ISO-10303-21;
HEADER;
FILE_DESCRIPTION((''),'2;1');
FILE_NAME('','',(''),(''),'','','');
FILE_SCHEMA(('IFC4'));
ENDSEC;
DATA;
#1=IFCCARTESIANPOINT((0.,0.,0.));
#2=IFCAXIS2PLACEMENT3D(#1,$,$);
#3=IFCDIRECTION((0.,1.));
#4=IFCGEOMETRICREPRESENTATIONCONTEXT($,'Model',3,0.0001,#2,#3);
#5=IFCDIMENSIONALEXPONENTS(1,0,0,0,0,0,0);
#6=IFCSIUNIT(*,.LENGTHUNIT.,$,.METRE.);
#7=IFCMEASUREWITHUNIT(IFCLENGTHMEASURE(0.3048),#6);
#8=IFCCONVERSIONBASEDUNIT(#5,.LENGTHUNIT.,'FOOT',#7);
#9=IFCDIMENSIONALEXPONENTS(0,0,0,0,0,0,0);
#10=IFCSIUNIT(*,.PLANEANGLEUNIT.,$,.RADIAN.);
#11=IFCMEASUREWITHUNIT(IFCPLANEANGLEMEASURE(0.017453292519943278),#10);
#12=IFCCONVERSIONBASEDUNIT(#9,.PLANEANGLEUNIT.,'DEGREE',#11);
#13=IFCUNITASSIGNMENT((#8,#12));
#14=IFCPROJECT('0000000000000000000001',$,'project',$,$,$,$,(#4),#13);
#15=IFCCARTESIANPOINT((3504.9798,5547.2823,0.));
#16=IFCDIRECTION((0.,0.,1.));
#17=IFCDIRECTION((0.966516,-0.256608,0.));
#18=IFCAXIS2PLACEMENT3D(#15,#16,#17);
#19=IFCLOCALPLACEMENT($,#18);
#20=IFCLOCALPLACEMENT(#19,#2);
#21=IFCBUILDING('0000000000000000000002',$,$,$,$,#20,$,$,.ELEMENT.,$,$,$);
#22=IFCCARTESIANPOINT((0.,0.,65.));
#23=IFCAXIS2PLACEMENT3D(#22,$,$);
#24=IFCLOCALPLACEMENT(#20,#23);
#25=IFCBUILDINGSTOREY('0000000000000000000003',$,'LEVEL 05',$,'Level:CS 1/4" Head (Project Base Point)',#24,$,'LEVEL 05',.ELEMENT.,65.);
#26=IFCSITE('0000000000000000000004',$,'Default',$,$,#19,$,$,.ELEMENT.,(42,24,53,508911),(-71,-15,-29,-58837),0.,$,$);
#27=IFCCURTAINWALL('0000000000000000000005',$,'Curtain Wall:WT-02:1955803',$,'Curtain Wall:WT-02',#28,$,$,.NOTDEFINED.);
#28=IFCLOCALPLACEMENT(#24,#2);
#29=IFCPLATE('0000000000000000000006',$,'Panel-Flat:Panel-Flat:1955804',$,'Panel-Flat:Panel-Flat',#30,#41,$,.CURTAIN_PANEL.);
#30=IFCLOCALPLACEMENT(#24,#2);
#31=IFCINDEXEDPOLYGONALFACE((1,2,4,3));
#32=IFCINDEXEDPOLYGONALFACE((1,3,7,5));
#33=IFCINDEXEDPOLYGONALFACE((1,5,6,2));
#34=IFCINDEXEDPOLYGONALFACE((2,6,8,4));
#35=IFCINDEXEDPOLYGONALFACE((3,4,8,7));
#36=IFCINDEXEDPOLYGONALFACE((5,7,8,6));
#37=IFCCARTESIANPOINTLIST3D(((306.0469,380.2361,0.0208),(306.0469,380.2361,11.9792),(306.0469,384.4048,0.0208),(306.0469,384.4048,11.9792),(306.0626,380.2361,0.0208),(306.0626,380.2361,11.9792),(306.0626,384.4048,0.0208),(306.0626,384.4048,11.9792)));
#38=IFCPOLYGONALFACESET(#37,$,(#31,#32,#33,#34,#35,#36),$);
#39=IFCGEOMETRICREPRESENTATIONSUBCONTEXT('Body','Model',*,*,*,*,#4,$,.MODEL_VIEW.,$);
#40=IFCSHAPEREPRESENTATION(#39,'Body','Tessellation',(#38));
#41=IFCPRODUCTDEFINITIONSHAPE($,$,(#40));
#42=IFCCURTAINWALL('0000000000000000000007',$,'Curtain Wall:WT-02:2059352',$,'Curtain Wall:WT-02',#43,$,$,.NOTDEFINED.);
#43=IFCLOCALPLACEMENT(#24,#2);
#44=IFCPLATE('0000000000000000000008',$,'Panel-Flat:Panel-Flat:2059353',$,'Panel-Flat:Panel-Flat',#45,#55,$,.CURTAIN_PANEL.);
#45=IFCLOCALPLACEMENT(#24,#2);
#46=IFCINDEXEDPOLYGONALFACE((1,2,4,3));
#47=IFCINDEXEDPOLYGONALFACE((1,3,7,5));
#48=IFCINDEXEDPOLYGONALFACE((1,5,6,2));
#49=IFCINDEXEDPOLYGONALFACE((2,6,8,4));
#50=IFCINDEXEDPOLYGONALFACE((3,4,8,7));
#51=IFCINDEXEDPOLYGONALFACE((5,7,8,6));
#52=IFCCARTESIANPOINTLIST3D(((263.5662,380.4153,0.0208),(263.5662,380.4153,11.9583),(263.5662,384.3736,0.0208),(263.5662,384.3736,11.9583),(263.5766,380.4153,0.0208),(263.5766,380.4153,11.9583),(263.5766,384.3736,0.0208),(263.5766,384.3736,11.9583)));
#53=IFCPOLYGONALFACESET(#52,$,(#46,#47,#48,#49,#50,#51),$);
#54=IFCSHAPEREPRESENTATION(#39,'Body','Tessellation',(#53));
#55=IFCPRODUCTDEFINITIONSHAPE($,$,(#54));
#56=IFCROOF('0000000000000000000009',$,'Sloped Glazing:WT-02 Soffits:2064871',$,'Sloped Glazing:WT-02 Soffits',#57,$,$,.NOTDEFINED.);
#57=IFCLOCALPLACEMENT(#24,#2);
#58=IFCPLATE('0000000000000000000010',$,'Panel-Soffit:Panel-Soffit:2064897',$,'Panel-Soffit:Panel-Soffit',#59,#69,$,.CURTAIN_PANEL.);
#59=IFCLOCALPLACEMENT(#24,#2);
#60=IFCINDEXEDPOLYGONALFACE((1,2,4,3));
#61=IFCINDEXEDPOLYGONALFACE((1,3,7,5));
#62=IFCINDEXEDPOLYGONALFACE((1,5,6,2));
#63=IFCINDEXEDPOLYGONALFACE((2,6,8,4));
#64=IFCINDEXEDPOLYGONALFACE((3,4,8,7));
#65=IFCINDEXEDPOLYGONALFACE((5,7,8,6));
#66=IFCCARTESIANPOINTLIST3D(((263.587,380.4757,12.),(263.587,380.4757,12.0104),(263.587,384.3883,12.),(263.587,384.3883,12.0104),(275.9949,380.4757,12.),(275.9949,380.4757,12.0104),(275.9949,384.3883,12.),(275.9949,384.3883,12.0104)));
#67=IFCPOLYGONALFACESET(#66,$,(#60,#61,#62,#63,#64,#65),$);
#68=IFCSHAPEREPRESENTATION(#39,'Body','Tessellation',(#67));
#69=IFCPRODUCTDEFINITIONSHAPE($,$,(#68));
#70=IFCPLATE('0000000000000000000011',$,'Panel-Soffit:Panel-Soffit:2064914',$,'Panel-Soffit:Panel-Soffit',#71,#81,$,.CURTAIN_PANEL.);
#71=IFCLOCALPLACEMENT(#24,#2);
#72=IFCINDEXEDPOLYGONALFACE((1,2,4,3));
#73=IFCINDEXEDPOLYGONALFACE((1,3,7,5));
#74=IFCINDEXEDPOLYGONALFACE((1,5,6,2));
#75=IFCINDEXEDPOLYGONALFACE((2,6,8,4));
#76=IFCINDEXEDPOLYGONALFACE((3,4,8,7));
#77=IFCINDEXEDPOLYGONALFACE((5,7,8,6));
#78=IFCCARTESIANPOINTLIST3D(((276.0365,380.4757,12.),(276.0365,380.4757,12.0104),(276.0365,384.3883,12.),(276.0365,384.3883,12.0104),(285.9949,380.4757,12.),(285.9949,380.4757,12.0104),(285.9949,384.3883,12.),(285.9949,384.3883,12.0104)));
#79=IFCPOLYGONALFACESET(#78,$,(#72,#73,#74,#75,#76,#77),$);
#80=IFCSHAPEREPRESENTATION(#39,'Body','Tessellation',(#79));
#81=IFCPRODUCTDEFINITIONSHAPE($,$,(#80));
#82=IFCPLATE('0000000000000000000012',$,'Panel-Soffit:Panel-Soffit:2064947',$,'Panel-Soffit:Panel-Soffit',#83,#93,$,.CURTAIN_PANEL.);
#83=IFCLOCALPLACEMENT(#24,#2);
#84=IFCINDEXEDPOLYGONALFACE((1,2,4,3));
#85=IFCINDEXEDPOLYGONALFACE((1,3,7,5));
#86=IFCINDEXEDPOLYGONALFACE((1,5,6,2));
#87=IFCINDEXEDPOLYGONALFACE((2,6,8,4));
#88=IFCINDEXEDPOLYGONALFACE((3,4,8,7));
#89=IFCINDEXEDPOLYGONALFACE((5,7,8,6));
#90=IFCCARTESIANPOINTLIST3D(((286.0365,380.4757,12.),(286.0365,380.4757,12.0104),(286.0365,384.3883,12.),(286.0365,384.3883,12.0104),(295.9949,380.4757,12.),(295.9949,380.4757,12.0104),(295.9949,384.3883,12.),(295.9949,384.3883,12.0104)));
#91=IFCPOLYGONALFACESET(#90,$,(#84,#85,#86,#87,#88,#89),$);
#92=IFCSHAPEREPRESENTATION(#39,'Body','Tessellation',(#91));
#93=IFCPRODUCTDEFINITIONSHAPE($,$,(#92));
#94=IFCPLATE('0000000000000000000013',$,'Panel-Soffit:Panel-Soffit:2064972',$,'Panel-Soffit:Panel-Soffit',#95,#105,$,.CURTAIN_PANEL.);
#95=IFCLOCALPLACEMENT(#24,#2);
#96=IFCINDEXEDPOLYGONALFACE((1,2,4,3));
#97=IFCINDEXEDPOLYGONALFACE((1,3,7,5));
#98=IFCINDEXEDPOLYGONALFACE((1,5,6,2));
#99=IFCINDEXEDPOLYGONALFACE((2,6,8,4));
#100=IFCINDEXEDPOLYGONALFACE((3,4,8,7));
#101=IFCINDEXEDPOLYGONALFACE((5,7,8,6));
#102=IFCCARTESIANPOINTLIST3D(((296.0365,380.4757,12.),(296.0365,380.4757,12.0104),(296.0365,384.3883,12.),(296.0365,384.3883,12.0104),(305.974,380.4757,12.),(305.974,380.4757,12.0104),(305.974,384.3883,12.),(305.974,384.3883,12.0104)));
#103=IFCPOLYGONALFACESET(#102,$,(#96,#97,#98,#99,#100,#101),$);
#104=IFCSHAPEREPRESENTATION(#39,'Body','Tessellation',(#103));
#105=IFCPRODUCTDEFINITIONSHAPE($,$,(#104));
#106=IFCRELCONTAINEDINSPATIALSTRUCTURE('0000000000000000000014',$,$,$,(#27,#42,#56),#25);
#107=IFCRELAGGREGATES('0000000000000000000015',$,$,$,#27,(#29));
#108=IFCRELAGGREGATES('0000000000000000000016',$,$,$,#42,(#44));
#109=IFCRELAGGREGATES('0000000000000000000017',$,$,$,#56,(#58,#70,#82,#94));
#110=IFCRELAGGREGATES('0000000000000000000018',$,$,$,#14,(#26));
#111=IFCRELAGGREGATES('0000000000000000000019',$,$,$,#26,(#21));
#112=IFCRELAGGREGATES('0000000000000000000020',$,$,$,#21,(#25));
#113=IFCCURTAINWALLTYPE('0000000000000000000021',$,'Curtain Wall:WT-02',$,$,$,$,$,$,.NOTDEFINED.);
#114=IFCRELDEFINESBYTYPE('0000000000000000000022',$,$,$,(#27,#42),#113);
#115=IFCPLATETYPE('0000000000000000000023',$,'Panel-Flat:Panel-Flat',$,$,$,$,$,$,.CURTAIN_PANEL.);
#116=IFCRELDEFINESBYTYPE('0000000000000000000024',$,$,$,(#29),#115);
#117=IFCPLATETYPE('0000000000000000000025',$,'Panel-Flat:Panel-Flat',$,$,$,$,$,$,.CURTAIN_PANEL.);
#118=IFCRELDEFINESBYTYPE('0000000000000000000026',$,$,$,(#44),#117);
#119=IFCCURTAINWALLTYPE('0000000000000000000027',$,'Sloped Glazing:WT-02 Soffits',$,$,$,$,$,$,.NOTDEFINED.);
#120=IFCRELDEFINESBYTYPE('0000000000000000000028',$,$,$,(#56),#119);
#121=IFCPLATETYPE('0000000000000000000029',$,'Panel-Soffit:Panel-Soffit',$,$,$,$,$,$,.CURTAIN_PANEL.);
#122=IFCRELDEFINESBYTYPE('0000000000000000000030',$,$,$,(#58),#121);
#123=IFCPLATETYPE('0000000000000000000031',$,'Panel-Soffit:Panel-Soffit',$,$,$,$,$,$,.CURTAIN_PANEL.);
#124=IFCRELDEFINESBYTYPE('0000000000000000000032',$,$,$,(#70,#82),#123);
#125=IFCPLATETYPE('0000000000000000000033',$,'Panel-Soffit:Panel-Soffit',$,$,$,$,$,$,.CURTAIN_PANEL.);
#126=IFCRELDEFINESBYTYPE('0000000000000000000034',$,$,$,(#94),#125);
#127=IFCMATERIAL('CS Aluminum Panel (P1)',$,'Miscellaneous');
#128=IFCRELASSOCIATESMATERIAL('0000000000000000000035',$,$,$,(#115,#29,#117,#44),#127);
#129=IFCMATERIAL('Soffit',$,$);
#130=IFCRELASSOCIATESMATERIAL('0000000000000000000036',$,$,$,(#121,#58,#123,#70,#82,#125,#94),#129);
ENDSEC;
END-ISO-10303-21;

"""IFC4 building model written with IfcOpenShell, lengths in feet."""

from ifc_helpers import new_model, entity, si_unit, converted_unit, direction, frame, origin, place, context, subcontext, project, spatial, indexed_curve, outline, extrude, source, transform, mapped, material, type_object, type_shapes, element, aggregate, save


model = new_model("IFC4")

# Units and contexts
model_context = context("Model", 3, precision=0.0001, world=origin(), true_north=direction((0.0, 1.0)))
body_context = subcontext(model_context, "Body", "Model", "MODEL_VIEW")
ifc_project = project(units=[converted_unit("LENGTHUNIT", "FOOT", entity("IfcLengthMeasure", 0.3048), si_unit("LENGTHUNIT", "METRE"), dimensions=[1, 0, 0, 0, 0, 0, 0]), converted_unit("PLANEANGLEUNIT", "DEGREE", entity("IfcPlaneAngleMeasure", 0.017453292519943278), si_unit("PLANEANGLEUNIT", "RADIAN"), dimensions=[0, 0, 0, 0, 0, 0, 0])], contexts=[model_context])

# Site, building, storey
site_placement = place(None, frame((3504.9798, 5547.2823, 0.0), z_axis=(0.0, 0.0, 1.0), x_axis=(0.966516, -0.256608, 0.0)))
site = spatial("IfcSite", under=ifc_project, at=site_placement, Name="Default", CompositionType="ELEMENT", RefLatitude=(42, 24, 53, 508911), RefLongitude=(-71, -15, -29, -58837), RefElevation=0.0)
building_placement = place(site_placement, origin())
building = spatial("IfcBuilding", under=site, at=building_placement, CompositionType="ELEMENT")
storey_placement = place(building_placement, frame((0.0, 0.0, 65.0)))
storey = spatial("IfcBuildingStorey", under=building, at=storey_placement, Name="LEVEL 05", ObjectType="Level:CS 1/4\" Head (Project Base Point)", LongName="LEVEL 05", CompositionType="ELEMENT", Elevation=65.0)

# Curtain wall, plate
curtain_wall_type_1 = type_object("IfcCurtainWallType", Name="Curtain Wall:WT-02", PredefinedType="NOTDEFINED")
curtain_wall_1_placement = place(storey_placement, frame((0.0, 0.0, -65.0)))
curtain_wall_1 = element("IfcCurtainWall", 1, at=curtain_wall_1_placement, inside=storey, type_object=curtain_wall_type_1, Name="Curtain Wall:WT-02:1955803", ObjectType="Curtain Wall:WT-02", PredefinedType="NOTDEFINED")
ifc_material_1 = material(Name="CS Aluminum Panel (P1)", Category="Miscellaneous")
plate_type_1 = type_object("IfcPlateType", Name="Panel-Flat:Panel-Flat", PredefinedType="CURTAIN_PANEL", material=ifc_material_1)
shared_shape_1 = source(origin(), body_context, "Body", "SweptSolid", [
    extrude(outline(indexed_curve([(-0.0078, -2.0843), (0.0078, -2.0843), (0.0078, 2.0843), (-0.0078, 2.0843), (-0.0078, -2.0843)], self_intersect=False)), frame((0.0, -0.0078, 0.0208), z_axis=(0.0, 0.0, 1.0), x_axis=(0.0, -1.0, 0.0)), (0.0, 0.0, 1.0), 11.9583),
])
type_shapes(plate_type_1, [shared_shape_1])
plate_1_placement = place(curtain_wall_1_placement, frame((306.0469, 382.3205, 65.0), z_axis=(0.0, 0.0, 1.0), x_axis=(0.0, 1.0, 0.0)))
plate_1 = element("IfcPlate", 2, at=plate_1_placement, type_object=plate_type_1, material=ifc_material_1, Name="Panel-Flat:Panel-Flat:1955804", ObjectType="Panel-Flat:Panel-Flat", PredefinedType="CURTAIN_PANEL", context=body_context, shape_type="MappedRepresentation", body=[
    mapped(shared_shape_1, transform((0.0, 0.0, 0.0), scale=1.0)),
])
aggregate(curtain_wall_1, [plate_1])

# Curtain wall, plate
curtain_wall_2_placement = place(storey_placement, frame((0.0, 0.0, -65.0)))
curtain_wall_2 = element("IfcCurtainWall", 3, at=curtain_wall_2_placement, inside=storey, type_object=curtain_wall_type_1, Name="Curtain Wall:WT-02:2059352", ObjectType="Curtain Wall:WT-02", PredefinedType="NOTDEFINED")
plate_type_2 = type_object("IfcPlateType", Name="Panel-Flat:Panel-Flat", PredefinedType="CURTAIN_PANEL", material=ifc_material_1)
shared_shape_2 = source(origin(), body_context, "Body", "SweptSolid", [
    extrude(outline(indexed_curve([(-0.0052, -1.9792), (0.0052, -1.9792), (0.0052, 1.9792), (-0.0052, 1.9792), (-0.0052, -1.9792)], self_intersect=False)), frame((0.0, -0.0052, 0.0208), z_axis=(0.0, 0.0, 1.0), x_axis=(0.0, -1.0, 0.0)), (0.0, 0.0, 1.0), 11.9375),
])
type_shapes(plate_type_2, [shared_shape_2])
plate_2_placement = place(curtain_wall_2_placement, frame((263.5766, 382.3944, 65.0), z_axis=(0.0, 0.0, 1.0), x_axis=(0.0, -1.0, 0.0)))
plate_2 = element("IfcPlate", 4, at=plate_2_placement, type_object=plate_type_2, material=ifc_material_1, Name="Panel-Flat:Panel-Flat:2059353", ObjectType="Panel-Flat:Panel-Flat", PredefinedType="CURTAIN_PANEL", context=body_context, shape_type="MappedRepresentation", body=[
    mapped(shared_shape_2, transform((0.0, 0.0, 0.0), scale=1.0)),
])
aggregate(curtain_wall_2, [plate_2])

# Roof, plates
curtain_wall_type_2 = type_object("IfcCurtainWallType", Name="Sloped Glazing:WT-02 Soffits", PredefinedType="NOTDEFINED")
roof_placement = place(storey_placement, frame((0.0, 0.0, -65.0)))
roof = element("IfcRoof", 5, at=roof_placement, inside=storey, type_object=curtain_wall_type_2, Name="Sloped Glazing:WT-02 Soffits:2064871", ObjectType="Sloped Glazing:WT-02 Soffits", PredefinedType="NOTDEFINED")
ifc_material_2 = material(Name="Soffit")
plate_type_3 = type_object("IfcPlateType", Name="Panel-Soffit:Panel-Soffit", PredefinedType="CURTAIN_PANEL", material=ifc_material_2)
shared_shape_3 = source(origin(), body_context, "Body", "SweptSolid", [
    extrude(outline(indexed_curve([(-0.0052, -6.2039), (0.0052, -6.2039), (0.0052, 6.2039), (-0.0052, 6.2039), (-0.0052, -6.2039)], self_intersect=False)), frame((0.0, -0.0052, 0.0208), z_axis=(0.0, 0.0, 1.0), x_axis=(0.0, -1.0, 0.0)), (0.0, 0.0, 1.0), 3.9126),
])
type_shapes(plate_type_3, [shared_shape_3])
plate_3_placement = place(roof_placement, frame((269.7909, 380.4549, 77.0), z_axis=(0.0, 1.0, 0.0), x_axis=(1.0, 0.0, 0.0)))
plate_3 = element("IfcPlate", 6, at=plate_3_placement, type_object=plate_type_3, material=ifc_material_2, Name="Panel-Soffit:Panel-Soffit:2064897", ObjectType="Panel-Soffit:Panel-Soffit", PredefinedType="CURTAIN_PANEL", context=body_context, shape_type="MappedRepresentation", body=[
    mapped(shared_shape_3, transform((0.0, 0.0, 0.0), scale=1.0)),
])
plate_type_4 = type_object("IfcPlateType", Name="Panel-Soffit:Panel-Soffit", PredefinedType="CURTAIN_PANEL", material=ifc_material_2)
shared_shape_4 = source(origin(), body_context, "Body", "SweptSolid", [
    extrude(outline(indexed_curve([(-0.0052, -4.9792), (0.0052, -4.9792), (0.0052, 4.9792), (-0.0052, 4.9792), (-0.0052, -4.9792)], self_intersect=False)), frame((0.0, -0.0052, 0.0208), z_axis=(0.0, 0.0, 1.0), x_axis=(0.0, -1.0, 0.0)), (0.0, 0.0, 1.0), 3.9126),
])
type_shapes(plate_type_4, [shared_shape_4])
plate_4_placement = place(roof_placement, frame((281.0157, 380.4549, 77.0), z_axis=(0.0, 1.0, 0.0), x_axis=(1.0, 0.0, 0.0)))
plate_4 = element("IfcPlate", 7, at=plate_4_placement, type_object=plate_type_4, material=ifc_material_2, Name="Panel-Soffit:Panel-Soffit:2064914", ObjectType="Panel-Soffit:Panel-Soffit", PredefinedType="CURTAIN_PANEL", context=body_context, shape_type="MappedRepresentation", body=[
    mapped(shared_shape_4, transform((0.0, 0.0, 0.0), scale=1.0)),
])
plate_5_placement = place(roof_placement, frame((291.0157, 380.4549, 77.0), z_axis=(0.0, 1.0, 0.0), x_axis=(1.0, 0.0, 0.0)))
plate_5 = element("IfcPlate", 8, at=plate_5_placement, type_object=plate_type_4, material=ifc_material_2, Name="Panel-Soffit:Panel-Soffit:2064947", ObjectType="Panel-Soffit:Panel-Soffit", PredefinedType="CURTAIN_PANEL", context=body_context, shape_type="MappedRepresentation", body=[
    mapped(shared_shape_4, transform((0.0, 0.0, 0.0), scale=1.0)),
])
plate_type_5 = type_object("IfcPlateType", Name="Panel-Soffit:Panel-Soffit", PredefinedType="CURTAIN_PANEL", material=ifc_material_2)
shared_shape_5 = source(origin(), body_context, "Body", "SweptSolid", [
    extrude(outline(indexed_curve([(-0.0052, -4.9687), (0.0052, -4.9687), (0.0052, 4.9687), (-0.0052, 4.9687), (-0.0052, -4.9687)], self_intersect=False)), frame((0.0, -0.0052, 0.0208), z_axis=(0.0, 0.0, 1.0), x_axis=(0.0, -1.0, 0.0)), (0.0, 0.0, 1.0), 3.9126),
])
type_shapes(plate_type_5, [shared_shape_5])
plate_6_placement = place(roof_placement, frame((301.0053, 380.4549, 77.0), z_axis=(0.0, 1.0, 0.0), x_axis=(1.0, 0.0, 0.0)))
plate_6 = element("IfcPlate", 9, at=plate_6_placement, type_object=plate_type_5, material=ifc_material_2, Name="Panel-Soffit:Panel-Soffit:2064972", ObjectType="Panel-Soffit:Panel-Soffit", PredefinedType="CURTAIN_PANEL", context=body_context, shape_type="MappedRepresentation", body=[
    mapped(shared_shape_5, transform((0.0, 0.0, 0.0), scale=1.0)),
])
aggregate(roof, [plate_3, plate_4, plate_5, plate_6])

save(model, "model.ifc")
